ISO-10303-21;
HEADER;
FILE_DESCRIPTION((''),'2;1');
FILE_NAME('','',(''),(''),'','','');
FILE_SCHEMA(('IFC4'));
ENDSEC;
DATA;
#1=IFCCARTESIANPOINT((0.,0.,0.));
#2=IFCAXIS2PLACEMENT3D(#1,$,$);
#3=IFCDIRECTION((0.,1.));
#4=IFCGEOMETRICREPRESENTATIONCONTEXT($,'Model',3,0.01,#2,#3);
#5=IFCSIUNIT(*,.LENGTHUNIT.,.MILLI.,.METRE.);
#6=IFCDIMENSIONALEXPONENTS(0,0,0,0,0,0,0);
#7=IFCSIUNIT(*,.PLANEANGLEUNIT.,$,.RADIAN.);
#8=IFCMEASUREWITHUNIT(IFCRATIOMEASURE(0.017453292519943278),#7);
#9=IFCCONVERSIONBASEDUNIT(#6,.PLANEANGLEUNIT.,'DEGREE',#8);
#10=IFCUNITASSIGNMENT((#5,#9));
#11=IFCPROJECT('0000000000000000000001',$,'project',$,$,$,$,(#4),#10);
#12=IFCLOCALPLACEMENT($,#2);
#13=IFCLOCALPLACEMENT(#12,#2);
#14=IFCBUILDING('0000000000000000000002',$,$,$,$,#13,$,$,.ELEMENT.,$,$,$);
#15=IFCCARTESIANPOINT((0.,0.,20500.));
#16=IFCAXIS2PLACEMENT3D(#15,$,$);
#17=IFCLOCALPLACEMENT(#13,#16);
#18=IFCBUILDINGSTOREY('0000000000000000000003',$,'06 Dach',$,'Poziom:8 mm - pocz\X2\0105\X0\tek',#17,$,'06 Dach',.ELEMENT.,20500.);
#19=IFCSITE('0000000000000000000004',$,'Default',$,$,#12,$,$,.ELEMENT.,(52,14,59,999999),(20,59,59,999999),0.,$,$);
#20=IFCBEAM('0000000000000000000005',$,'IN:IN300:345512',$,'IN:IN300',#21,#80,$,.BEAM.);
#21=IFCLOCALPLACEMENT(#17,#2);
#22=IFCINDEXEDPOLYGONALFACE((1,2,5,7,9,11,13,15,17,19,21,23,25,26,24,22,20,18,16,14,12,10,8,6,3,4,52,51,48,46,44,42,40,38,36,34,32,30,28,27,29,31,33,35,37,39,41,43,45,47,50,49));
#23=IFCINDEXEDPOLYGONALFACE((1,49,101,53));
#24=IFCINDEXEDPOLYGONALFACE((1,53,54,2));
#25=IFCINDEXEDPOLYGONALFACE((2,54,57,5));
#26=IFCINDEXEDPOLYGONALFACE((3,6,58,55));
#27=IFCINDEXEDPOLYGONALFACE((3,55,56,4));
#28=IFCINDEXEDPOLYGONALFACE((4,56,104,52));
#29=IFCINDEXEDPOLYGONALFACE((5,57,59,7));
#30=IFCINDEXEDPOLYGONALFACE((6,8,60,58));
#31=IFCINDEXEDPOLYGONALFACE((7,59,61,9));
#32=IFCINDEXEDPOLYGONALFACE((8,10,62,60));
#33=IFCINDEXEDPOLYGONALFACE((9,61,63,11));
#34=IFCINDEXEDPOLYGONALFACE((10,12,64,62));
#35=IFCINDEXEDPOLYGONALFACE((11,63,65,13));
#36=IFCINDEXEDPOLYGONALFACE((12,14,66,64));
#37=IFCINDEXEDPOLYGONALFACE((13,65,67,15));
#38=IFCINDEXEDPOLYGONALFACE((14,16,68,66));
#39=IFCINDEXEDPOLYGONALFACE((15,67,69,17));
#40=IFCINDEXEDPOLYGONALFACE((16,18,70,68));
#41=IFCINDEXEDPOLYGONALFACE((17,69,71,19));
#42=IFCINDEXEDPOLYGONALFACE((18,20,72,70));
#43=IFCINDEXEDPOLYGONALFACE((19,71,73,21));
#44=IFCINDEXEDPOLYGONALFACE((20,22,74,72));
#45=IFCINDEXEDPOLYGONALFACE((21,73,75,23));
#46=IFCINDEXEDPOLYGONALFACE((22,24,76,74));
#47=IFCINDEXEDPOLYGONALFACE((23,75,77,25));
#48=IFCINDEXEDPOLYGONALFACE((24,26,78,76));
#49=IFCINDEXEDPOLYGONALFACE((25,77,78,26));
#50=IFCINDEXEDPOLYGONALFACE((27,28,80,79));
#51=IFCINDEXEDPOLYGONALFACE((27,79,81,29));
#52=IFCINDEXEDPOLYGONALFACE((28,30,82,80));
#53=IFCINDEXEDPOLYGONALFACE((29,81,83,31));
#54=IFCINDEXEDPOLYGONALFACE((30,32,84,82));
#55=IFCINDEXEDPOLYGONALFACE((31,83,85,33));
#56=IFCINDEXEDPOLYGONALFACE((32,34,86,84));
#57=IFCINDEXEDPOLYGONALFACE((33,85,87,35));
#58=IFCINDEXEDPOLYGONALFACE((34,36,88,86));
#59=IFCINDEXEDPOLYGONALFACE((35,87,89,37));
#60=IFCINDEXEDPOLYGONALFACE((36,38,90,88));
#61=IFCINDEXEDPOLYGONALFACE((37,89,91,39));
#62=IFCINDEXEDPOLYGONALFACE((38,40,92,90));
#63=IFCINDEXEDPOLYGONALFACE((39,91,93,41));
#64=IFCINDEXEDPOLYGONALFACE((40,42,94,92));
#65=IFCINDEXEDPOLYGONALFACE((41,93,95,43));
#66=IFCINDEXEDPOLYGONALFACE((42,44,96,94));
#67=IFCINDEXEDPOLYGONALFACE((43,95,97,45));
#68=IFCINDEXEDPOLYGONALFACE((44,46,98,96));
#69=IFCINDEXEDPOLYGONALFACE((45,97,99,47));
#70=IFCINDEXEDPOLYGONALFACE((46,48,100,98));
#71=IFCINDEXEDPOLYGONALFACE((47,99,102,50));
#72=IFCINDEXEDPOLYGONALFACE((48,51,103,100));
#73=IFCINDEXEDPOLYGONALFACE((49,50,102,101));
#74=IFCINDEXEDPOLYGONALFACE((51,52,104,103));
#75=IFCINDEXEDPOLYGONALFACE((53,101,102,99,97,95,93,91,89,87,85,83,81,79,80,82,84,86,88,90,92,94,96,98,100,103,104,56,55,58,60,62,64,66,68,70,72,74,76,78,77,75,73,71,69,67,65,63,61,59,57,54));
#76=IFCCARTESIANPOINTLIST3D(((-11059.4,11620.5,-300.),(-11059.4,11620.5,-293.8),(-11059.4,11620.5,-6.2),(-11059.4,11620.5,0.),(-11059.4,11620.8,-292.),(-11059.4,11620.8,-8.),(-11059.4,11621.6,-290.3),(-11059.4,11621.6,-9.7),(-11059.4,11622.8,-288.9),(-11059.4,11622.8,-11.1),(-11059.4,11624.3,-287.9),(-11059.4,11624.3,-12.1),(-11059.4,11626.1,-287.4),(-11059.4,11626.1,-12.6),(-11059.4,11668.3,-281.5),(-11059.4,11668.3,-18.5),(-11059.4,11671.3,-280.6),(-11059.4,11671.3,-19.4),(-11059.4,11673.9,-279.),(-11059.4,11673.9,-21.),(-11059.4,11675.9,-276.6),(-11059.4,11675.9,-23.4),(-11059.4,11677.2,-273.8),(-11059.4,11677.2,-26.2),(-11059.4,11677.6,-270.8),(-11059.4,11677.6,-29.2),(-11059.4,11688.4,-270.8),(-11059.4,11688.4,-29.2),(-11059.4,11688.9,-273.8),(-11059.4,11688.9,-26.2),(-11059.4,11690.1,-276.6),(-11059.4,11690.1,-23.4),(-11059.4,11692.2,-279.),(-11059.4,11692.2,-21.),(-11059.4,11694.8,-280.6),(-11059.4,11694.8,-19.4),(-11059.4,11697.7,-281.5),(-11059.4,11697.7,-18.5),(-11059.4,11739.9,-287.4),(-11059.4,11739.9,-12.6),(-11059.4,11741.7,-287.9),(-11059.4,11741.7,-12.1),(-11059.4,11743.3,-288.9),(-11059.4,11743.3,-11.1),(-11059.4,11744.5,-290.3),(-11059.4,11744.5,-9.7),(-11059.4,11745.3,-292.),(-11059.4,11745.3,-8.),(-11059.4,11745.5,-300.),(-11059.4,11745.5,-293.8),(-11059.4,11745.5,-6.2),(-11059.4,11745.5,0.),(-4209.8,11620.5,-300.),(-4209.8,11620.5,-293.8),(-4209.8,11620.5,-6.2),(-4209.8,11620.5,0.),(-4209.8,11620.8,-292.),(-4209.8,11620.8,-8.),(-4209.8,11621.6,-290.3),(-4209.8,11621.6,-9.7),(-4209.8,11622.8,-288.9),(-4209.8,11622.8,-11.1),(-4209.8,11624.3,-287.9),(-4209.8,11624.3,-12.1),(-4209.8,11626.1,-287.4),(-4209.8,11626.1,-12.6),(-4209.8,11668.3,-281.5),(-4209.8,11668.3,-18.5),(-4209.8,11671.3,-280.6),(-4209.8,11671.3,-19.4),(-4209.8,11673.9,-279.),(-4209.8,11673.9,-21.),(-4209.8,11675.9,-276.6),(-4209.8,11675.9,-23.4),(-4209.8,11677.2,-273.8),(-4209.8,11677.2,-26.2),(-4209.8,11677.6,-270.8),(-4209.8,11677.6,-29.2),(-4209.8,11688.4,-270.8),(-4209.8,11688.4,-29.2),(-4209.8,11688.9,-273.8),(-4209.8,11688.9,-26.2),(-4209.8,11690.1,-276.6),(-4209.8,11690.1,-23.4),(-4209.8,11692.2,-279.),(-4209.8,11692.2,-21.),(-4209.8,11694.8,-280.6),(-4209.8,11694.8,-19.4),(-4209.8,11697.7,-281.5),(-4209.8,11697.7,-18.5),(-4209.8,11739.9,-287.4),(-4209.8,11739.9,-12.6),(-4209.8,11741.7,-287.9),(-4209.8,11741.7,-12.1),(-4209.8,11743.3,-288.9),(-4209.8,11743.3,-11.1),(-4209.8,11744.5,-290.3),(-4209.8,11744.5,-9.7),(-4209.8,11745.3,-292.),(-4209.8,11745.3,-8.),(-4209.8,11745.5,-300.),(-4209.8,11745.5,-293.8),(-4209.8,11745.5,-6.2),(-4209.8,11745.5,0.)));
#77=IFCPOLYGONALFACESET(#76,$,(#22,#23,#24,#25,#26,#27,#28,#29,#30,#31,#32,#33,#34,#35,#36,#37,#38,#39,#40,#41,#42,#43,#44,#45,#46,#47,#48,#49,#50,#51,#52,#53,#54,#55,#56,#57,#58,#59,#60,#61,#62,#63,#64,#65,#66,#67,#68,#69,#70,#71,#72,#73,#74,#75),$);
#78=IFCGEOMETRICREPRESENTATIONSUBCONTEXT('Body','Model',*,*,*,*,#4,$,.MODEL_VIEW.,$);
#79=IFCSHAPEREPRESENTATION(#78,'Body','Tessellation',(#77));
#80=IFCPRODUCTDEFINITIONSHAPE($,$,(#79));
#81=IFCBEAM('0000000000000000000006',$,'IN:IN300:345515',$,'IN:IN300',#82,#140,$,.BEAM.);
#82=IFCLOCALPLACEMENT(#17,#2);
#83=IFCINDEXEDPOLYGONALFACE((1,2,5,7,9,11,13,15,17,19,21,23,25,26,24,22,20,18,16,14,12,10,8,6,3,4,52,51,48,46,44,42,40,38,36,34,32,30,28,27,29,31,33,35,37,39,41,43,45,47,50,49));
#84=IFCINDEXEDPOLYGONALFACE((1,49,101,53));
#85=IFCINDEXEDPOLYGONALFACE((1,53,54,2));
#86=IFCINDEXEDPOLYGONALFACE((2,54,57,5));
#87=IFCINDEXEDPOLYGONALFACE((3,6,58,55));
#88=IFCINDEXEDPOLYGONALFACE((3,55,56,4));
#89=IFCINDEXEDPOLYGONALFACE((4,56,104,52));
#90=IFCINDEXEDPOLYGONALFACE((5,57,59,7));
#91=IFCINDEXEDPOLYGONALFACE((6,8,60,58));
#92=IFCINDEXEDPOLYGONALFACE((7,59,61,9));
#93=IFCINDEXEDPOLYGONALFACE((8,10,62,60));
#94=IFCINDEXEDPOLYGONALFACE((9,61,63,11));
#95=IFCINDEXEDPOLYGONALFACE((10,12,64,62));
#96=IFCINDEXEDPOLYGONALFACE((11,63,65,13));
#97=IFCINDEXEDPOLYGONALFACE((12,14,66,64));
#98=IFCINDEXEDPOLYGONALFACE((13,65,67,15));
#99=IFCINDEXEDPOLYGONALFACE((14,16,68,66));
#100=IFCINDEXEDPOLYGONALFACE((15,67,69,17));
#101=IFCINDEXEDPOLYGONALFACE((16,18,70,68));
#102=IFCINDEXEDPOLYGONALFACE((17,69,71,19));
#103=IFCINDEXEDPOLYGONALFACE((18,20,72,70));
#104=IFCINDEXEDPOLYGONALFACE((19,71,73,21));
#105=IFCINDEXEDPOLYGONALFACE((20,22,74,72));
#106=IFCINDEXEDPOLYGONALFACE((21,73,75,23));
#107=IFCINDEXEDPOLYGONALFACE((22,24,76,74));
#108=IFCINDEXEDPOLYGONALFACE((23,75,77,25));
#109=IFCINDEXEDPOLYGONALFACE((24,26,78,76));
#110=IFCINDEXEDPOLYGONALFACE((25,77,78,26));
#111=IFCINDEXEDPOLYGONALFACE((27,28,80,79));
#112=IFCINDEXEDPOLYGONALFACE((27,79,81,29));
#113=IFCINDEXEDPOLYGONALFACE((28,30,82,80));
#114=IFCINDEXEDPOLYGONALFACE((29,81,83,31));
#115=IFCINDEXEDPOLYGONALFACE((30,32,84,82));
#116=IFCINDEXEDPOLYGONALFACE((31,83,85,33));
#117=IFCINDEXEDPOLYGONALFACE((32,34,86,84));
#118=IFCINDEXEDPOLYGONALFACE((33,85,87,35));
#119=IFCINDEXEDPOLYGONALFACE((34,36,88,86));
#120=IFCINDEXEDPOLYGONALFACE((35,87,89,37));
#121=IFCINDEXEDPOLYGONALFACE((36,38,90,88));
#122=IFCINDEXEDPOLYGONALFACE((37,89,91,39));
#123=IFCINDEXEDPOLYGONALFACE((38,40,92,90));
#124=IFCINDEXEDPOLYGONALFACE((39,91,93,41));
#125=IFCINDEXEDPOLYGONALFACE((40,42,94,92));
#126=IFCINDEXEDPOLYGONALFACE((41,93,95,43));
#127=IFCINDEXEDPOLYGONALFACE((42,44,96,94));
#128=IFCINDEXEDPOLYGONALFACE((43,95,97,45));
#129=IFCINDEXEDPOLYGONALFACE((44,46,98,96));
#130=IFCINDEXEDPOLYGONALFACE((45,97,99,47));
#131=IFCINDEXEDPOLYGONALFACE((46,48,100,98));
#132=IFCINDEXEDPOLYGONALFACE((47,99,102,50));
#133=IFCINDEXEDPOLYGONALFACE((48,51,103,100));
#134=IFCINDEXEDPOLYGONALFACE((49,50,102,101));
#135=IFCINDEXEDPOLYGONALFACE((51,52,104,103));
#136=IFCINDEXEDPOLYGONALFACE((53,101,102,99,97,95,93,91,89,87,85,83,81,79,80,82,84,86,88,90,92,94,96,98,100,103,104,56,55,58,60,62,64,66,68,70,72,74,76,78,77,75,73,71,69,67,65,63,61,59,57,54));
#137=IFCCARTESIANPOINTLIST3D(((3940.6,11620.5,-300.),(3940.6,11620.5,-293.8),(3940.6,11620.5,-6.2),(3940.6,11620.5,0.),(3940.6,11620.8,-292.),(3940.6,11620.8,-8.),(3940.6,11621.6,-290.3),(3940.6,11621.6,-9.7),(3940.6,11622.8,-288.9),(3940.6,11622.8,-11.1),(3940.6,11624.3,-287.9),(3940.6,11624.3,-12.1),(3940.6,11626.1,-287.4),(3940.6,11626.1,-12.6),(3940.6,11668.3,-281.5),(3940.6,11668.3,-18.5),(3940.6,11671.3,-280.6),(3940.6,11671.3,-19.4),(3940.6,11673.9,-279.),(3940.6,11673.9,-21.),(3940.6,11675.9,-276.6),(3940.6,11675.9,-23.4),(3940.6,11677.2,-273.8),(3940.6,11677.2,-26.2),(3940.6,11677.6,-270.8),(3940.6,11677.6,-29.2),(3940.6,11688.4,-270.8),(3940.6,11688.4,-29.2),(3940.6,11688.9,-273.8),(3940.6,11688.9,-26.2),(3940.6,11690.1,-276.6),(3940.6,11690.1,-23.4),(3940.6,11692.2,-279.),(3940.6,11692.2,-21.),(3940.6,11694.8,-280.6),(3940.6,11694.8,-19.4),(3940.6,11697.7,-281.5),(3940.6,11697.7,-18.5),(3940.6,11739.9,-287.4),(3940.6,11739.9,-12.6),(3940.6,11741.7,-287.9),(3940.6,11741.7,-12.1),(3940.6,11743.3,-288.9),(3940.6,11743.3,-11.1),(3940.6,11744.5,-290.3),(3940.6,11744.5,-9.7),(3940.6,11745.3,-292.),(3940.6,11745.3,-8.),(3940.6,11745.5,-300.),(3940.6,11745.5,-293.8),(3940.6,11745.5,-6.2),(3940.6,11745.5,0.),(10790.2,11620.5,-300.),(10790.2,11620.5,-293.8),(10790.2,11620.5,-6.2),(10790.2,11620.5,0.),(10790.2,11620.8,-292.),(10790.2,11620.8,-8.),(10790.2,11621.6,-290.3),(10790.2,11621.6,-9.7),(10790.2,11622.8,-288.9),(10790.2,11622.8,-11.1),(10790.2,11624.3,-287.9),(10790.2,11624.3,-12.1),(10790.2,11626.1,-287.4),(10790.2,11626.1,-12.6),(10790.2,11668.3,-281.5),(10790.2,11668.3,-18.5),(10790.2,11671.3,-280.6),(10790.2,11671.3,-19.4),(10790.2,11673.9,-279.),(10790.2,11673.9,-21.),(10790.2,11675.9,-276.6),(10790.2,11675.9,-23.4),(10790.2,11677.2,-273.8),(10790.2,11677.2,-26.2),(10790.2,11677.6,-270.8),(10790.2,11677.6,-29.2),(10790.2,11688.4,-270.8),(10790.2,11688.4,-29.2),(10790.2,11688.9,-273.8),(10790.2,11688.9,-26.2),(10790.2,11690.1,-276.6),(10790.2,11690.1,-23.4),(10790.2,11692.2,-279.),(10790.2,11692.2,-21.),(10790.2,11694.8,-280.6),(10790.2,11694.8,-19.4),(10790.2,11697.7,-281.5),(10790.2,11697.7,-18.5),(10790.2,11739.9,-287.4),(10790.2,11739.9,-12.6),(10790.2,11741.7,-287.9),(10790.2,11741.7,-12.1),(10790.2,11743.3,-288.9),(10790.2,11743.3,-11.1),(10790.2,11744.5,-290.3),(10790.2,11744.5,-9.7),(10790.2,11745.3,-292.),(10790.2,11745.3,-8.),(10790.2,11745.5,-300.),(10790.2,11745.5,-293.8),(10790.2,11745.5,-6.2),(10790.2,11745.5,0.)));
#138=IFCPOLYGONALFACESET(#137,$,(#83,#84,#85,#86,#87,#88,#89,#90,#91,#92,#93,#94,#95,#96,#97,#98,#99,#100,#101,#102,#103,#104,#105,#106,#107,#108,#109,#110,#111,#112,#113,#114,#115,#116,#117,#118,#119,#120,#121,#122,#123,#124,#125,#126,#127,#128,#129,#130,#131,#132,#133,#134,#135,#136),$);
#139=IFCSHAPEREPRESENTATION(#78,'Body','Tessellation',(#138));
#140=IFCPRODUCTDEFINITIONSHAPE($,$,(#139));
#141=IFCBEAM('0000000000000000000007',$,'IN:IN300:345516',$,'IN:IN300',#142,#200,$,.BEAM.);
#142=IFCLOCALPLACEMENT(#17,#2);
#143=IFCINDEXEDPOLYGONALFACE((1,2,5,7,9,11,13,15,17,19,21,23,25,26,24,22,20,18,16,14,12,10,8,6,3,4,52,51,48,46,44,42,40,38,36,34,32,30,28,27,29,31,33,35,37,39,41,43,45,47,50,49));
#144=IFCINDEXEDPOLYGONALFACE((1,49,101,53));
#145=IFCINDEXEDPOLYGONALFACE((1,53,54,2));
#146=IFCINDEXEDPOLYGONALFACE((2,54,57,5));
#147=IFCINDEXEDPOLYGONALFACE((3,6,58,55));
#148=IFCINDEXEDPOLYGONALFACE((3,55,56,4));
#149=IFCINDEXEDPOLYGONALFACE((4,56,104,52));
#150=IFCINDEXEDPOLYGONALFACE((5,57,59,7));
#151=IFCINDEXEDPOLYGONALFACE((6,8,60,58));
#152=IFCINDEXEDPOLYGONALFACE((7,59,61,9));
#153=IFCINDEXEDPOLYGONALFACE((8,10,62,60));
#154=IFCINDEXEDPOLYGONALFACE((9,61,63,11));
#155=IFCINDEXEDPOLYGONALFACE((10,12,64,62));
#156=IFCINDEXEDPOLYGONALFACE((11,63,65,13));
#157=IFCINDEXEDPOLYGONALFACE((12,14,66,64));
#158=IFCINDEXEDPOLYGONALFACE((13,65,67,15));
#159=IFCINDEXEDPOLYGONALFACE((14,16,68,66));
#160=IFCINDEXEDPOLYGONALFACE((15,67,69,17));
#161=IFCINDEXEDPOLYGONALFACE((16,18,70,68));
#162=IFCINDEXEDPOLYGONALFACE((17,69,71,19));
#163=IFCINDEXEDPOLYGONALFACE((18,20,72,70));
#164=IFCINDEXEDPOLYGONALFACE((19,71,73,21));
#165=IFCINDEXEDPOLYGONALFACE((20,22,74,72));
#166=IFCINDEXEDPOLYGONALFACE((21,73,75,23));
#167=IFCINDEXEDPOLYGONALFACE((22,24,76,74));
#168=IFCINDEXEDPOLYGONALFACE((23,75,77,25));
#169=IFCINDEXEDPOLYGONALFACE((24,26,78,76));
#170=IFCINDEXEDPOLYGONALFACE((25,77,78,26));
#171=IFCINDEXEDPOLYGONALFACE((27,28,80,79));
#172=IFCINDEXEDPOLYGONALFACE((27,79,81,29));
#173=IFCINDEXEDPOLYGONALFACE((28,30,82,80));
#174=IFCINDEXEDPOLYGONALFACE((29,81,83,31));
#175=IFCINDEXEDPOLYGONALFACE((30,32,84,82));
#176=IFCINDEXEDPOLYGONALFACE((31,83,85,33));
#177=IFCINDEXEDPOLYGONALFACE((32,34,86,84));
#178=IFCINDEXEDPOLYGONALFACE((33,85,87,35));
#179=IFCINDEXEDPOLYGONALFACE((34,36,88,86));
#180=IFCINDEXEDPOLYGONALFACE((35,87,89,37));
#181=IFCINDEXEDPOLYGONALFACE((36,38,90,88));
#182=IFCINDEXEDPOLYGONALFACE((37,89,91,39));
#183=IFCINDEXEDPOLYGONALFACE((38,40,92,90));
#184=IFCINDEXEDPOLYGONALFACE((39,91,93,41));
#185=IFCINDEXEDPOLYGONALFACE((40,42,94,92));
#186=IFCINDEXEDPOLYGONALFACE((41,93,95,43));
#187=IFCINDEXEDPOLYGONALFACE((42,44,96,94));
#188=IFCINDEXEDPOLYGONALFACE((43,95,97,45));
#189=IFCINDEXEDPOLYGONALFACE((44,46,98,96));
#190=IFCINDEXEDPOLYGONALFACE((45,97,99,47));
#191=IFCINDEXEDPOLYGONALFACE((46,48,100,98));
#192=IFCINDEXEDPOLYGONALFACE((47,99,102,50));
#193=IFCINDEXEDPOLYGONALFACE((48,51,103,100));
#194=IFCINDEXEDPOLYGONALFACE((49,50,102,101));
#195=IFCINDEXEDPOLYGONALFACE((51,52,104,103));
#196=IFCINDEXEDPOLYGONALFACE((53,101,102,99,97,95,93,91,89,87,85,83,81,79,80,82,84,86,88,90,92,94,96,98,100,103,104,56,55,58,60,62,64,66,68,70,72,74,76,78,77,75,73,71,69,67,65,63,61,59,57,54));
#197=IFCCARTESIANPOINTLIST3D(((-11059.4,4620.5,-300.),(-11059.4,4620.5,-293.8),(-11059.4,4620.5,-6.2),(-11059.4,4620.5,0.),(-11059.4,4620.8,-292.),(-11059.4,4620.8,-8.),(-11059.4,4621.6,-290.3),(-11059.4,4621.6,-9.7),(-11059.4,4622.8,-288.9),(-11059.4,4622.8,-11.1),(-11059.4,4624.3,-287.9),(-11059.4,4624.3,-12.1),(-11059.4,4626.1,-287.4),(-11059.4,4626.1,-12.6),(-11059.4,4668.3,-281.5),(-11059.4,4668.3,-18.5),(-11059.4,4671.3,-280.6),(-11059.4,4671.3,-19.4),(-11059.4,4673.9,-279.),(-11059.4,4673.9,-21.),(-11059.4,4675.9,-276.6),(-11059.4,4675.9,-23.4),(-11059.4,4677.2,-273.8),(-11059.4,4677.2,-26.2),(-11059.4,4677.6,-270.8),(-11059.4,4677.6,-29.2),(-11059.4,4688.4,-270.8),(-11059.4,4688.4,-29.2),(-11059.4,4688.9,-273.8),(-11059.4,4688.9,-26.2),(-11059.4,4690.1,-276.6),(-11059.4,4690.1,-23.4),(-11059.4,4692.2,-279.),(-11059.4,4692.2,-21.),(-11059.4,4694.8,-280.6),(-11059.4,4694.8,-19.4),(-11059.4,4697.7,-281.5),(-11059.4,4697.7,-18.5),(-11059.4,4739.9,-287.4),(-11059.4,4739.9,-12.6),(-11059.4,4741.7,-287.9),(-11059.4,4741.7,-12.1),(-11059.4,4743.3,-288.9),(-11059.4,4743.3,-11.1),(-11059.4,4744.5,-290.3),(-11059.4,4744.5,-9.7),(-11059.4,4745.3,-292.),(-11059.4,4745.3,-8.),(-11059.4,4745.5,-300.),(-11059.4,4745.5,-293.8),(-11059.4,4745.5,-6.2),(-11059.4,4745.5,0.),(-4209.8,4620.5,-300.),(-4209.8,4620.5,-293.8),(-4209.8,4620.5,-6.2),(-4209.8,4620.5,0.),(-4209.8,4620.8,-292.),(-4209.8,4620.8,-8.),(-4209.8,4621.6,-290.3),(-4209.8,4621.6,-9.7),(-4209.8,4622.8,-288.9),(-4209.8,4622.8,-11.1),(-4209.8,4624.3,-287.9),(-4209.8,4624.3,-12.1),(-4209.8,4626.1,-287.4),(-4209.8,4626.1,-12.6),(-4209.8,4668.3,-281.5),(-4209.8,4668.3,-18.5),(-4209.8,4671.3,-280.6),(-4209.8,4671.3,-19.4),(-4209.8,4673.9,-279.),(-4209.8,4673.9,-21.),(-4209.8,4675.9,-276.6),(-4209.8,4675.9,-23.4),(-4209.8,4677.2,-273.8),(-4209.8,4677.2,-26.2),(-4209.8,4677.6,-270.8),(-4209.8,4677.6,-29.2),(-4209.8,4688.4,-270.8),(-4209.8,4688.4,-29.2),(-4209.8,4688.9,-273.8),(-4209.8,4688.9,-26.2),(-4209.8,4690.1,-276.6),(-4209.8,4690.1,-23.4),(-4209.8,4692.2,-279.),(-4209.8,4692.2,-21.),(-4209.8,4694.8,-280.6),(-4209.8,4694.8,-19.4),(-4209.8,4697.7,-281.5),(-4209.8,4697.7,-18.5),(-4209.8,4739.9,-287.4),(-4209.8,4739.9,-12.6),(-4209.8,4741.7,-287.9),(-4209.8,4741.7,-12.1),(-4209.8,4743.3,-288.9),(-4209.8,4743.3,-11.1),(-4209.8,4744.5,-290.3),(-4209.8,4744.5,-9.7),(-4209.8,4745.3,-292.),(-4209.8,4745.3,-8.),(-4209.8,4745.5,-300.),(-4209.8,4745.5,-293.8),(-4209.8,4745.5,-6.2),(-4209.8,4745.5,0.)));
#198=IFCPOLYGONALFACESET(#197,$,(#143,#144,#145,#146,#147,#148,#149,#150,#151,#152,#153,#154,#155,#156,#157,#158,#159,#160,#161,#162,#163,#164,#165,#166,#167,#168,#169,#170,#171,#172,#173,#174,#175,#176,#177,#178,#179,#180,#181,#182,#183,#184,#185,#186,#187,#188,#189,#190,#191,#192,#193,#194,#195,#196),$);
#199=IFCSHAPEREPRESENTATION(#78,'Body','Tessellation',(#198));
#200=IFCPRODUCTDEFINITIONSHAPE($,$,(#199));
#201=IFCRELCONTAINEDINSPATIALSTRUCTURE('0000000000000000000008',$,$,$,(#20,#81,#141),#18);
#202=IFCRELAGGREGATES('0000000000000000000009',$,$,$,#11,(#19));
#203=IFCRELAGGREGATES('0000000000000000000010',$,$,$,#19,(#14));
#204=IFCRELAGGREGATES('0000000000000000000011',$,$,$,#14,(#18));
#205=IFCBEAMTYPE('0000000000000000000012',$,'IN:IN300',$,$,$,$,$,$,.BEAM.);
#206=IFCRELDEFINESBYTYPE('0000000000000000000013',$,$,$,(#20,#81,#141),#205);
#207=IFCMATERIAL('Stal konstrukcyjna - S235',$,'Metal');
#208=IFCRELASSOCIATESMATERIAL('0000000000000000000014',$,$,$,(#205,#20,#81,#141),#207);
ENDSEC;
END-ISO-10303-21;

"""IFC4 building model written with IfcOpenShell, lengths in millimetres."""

from ifc_helpers import new_model, entity, si_unit, converted_unit, direction, frame, origin, place, context, subcontext, project, spatial, line, arc, indexed_curve, outline, extrude, source, transform, mapped, material, type_object, type_shapes, element, save


model = new_model("IFC4")

# Units and contexts
model_context = context("Model", 3, precision=0.01, world=origin(), true_north=direction((0.0, 1.0)))
body_context = subcontext(model_context, "Body", "Model", "MODEL_VIEW")
ifc_project = project(units=[si_unit("LENGTHUNIT", "METRE", prefix="MILLI"), converted_unit("PLANEANGLEUNIT", "DEGREE", entity("IfcRatioMeasure", 0.017453292519943278), si_unit("PLANEANGLEUNIT", "RADIAN"), dimensions=[0, 0, 0, 0, 0, 0, 0])], contexts=[model_context])

# Site, building, storey
site_placement = place(None, origin())
site = spatial("IfcSite", under=ifc_project, at=site_placement, Name="Default", CompositionType="ELEMENT", RefLatitude=(52, 14, 59, 999999), RefLongitude=(20, 59, 59, 999999), RefElevation=0.0)
building_placement = place(site_placement, origin())
building = spatial("IfcBuilding", under=site, at=building_placement, CompositionType="ELEMENT")
storey_placement = place(building_placement, frame((0.0, 0.0, 20500.0)))
storey = spatial("IfcBuildingStorey", under=building, at=storey_placement, Name="06 Dach", ObjectType="Poziom:8 mm - początek", LongName="06 Dach", CompositionType="ELEMENT", Elevation=20500.0)

# Beams
ifc_material = material(Name="Stal konstrukcyjna - S235", Category="Metal")
beam_type_1 = type_object("IfcBeamType", Name="IN:IN300", PredefinedType="BEAM", material=ifc_material)
shared_shape_1 = source(origin(), body_context, "Body", "SweptSolid", [
    extrude(outline(indexed_curve([(143.8, -62.5), (150.0, -62.5), (150.0, 62.5), (143.8, 62.5), (139.6, 60.9), (137.4, 56.9), (131.5, 14.7), (127.9, 8.1), (120.8, 5.4), (-120.8, 5.4), (-127.9, 8.1), (-131.5, 14.7), (-137.4, 56.9), (-139.6, 60.9), (-143.8, 62.5), (-150.0, 62.5), (-150.0, -62.5), (-143.8, -62.5), (-139.6, -60.9), (-137.4, -56.9), (-131.5, -14.7), (-127.9, -8.1), (-120.8, -5.4), (120.8, -5.4), (127.9, -8.1), (131.5, -14.7), (137.4, -56.9), (139.6, -60.9)], segments=[line(1, 2, 3, 4), arc(4, 5, 6), line(6, 7), arc(7, 8, 9), line(9, 10), arc(10, 11, 12), line(12, 13), arc(13, 14, 15), line(15, 16, 17, 18), arc(18, 19, 20), line(20, 21), arc(21, 22, 23), line(23, 24), arc(24, 25, 26), line(26, 27), arc(27, 28, 1)], self_intersect=False)), frame((-3424.8, 0.0, 0.0), z_axis=(1.0, 0.0, 0.0), x_axis=(0.0, 0.0, -1.0)), (0.0, 0.0, 1.0), 6849.6),
])
type_shapes(beam_type_1, [shared_shape_1])
for number, where, name in (
    (1, (-7634.6, 11683.0, -150.0), "IN:IN300:345512"),
    (2, (7365.4, 11683.0, -150.0), "IN:IN300:345515"),
    (3, (-7634.6, 4683.0, -150.0), "IN:IN300:345516"),
):
    element("IfcBeam", number, at=place(storey_placement, frame(where)), inside=storey, type_object=beam_type_1, material=ifc_material, Name=name, ObjectType="IN:IN300", PredefinedType="BEAM", context=body_context, shape_type="MappedRepresentation", body=[
        mapped(shared_shape_1, transform((0.0, 0.0, 0.0), scale=1.0)),
    ])

save(model, "model.ifc")
